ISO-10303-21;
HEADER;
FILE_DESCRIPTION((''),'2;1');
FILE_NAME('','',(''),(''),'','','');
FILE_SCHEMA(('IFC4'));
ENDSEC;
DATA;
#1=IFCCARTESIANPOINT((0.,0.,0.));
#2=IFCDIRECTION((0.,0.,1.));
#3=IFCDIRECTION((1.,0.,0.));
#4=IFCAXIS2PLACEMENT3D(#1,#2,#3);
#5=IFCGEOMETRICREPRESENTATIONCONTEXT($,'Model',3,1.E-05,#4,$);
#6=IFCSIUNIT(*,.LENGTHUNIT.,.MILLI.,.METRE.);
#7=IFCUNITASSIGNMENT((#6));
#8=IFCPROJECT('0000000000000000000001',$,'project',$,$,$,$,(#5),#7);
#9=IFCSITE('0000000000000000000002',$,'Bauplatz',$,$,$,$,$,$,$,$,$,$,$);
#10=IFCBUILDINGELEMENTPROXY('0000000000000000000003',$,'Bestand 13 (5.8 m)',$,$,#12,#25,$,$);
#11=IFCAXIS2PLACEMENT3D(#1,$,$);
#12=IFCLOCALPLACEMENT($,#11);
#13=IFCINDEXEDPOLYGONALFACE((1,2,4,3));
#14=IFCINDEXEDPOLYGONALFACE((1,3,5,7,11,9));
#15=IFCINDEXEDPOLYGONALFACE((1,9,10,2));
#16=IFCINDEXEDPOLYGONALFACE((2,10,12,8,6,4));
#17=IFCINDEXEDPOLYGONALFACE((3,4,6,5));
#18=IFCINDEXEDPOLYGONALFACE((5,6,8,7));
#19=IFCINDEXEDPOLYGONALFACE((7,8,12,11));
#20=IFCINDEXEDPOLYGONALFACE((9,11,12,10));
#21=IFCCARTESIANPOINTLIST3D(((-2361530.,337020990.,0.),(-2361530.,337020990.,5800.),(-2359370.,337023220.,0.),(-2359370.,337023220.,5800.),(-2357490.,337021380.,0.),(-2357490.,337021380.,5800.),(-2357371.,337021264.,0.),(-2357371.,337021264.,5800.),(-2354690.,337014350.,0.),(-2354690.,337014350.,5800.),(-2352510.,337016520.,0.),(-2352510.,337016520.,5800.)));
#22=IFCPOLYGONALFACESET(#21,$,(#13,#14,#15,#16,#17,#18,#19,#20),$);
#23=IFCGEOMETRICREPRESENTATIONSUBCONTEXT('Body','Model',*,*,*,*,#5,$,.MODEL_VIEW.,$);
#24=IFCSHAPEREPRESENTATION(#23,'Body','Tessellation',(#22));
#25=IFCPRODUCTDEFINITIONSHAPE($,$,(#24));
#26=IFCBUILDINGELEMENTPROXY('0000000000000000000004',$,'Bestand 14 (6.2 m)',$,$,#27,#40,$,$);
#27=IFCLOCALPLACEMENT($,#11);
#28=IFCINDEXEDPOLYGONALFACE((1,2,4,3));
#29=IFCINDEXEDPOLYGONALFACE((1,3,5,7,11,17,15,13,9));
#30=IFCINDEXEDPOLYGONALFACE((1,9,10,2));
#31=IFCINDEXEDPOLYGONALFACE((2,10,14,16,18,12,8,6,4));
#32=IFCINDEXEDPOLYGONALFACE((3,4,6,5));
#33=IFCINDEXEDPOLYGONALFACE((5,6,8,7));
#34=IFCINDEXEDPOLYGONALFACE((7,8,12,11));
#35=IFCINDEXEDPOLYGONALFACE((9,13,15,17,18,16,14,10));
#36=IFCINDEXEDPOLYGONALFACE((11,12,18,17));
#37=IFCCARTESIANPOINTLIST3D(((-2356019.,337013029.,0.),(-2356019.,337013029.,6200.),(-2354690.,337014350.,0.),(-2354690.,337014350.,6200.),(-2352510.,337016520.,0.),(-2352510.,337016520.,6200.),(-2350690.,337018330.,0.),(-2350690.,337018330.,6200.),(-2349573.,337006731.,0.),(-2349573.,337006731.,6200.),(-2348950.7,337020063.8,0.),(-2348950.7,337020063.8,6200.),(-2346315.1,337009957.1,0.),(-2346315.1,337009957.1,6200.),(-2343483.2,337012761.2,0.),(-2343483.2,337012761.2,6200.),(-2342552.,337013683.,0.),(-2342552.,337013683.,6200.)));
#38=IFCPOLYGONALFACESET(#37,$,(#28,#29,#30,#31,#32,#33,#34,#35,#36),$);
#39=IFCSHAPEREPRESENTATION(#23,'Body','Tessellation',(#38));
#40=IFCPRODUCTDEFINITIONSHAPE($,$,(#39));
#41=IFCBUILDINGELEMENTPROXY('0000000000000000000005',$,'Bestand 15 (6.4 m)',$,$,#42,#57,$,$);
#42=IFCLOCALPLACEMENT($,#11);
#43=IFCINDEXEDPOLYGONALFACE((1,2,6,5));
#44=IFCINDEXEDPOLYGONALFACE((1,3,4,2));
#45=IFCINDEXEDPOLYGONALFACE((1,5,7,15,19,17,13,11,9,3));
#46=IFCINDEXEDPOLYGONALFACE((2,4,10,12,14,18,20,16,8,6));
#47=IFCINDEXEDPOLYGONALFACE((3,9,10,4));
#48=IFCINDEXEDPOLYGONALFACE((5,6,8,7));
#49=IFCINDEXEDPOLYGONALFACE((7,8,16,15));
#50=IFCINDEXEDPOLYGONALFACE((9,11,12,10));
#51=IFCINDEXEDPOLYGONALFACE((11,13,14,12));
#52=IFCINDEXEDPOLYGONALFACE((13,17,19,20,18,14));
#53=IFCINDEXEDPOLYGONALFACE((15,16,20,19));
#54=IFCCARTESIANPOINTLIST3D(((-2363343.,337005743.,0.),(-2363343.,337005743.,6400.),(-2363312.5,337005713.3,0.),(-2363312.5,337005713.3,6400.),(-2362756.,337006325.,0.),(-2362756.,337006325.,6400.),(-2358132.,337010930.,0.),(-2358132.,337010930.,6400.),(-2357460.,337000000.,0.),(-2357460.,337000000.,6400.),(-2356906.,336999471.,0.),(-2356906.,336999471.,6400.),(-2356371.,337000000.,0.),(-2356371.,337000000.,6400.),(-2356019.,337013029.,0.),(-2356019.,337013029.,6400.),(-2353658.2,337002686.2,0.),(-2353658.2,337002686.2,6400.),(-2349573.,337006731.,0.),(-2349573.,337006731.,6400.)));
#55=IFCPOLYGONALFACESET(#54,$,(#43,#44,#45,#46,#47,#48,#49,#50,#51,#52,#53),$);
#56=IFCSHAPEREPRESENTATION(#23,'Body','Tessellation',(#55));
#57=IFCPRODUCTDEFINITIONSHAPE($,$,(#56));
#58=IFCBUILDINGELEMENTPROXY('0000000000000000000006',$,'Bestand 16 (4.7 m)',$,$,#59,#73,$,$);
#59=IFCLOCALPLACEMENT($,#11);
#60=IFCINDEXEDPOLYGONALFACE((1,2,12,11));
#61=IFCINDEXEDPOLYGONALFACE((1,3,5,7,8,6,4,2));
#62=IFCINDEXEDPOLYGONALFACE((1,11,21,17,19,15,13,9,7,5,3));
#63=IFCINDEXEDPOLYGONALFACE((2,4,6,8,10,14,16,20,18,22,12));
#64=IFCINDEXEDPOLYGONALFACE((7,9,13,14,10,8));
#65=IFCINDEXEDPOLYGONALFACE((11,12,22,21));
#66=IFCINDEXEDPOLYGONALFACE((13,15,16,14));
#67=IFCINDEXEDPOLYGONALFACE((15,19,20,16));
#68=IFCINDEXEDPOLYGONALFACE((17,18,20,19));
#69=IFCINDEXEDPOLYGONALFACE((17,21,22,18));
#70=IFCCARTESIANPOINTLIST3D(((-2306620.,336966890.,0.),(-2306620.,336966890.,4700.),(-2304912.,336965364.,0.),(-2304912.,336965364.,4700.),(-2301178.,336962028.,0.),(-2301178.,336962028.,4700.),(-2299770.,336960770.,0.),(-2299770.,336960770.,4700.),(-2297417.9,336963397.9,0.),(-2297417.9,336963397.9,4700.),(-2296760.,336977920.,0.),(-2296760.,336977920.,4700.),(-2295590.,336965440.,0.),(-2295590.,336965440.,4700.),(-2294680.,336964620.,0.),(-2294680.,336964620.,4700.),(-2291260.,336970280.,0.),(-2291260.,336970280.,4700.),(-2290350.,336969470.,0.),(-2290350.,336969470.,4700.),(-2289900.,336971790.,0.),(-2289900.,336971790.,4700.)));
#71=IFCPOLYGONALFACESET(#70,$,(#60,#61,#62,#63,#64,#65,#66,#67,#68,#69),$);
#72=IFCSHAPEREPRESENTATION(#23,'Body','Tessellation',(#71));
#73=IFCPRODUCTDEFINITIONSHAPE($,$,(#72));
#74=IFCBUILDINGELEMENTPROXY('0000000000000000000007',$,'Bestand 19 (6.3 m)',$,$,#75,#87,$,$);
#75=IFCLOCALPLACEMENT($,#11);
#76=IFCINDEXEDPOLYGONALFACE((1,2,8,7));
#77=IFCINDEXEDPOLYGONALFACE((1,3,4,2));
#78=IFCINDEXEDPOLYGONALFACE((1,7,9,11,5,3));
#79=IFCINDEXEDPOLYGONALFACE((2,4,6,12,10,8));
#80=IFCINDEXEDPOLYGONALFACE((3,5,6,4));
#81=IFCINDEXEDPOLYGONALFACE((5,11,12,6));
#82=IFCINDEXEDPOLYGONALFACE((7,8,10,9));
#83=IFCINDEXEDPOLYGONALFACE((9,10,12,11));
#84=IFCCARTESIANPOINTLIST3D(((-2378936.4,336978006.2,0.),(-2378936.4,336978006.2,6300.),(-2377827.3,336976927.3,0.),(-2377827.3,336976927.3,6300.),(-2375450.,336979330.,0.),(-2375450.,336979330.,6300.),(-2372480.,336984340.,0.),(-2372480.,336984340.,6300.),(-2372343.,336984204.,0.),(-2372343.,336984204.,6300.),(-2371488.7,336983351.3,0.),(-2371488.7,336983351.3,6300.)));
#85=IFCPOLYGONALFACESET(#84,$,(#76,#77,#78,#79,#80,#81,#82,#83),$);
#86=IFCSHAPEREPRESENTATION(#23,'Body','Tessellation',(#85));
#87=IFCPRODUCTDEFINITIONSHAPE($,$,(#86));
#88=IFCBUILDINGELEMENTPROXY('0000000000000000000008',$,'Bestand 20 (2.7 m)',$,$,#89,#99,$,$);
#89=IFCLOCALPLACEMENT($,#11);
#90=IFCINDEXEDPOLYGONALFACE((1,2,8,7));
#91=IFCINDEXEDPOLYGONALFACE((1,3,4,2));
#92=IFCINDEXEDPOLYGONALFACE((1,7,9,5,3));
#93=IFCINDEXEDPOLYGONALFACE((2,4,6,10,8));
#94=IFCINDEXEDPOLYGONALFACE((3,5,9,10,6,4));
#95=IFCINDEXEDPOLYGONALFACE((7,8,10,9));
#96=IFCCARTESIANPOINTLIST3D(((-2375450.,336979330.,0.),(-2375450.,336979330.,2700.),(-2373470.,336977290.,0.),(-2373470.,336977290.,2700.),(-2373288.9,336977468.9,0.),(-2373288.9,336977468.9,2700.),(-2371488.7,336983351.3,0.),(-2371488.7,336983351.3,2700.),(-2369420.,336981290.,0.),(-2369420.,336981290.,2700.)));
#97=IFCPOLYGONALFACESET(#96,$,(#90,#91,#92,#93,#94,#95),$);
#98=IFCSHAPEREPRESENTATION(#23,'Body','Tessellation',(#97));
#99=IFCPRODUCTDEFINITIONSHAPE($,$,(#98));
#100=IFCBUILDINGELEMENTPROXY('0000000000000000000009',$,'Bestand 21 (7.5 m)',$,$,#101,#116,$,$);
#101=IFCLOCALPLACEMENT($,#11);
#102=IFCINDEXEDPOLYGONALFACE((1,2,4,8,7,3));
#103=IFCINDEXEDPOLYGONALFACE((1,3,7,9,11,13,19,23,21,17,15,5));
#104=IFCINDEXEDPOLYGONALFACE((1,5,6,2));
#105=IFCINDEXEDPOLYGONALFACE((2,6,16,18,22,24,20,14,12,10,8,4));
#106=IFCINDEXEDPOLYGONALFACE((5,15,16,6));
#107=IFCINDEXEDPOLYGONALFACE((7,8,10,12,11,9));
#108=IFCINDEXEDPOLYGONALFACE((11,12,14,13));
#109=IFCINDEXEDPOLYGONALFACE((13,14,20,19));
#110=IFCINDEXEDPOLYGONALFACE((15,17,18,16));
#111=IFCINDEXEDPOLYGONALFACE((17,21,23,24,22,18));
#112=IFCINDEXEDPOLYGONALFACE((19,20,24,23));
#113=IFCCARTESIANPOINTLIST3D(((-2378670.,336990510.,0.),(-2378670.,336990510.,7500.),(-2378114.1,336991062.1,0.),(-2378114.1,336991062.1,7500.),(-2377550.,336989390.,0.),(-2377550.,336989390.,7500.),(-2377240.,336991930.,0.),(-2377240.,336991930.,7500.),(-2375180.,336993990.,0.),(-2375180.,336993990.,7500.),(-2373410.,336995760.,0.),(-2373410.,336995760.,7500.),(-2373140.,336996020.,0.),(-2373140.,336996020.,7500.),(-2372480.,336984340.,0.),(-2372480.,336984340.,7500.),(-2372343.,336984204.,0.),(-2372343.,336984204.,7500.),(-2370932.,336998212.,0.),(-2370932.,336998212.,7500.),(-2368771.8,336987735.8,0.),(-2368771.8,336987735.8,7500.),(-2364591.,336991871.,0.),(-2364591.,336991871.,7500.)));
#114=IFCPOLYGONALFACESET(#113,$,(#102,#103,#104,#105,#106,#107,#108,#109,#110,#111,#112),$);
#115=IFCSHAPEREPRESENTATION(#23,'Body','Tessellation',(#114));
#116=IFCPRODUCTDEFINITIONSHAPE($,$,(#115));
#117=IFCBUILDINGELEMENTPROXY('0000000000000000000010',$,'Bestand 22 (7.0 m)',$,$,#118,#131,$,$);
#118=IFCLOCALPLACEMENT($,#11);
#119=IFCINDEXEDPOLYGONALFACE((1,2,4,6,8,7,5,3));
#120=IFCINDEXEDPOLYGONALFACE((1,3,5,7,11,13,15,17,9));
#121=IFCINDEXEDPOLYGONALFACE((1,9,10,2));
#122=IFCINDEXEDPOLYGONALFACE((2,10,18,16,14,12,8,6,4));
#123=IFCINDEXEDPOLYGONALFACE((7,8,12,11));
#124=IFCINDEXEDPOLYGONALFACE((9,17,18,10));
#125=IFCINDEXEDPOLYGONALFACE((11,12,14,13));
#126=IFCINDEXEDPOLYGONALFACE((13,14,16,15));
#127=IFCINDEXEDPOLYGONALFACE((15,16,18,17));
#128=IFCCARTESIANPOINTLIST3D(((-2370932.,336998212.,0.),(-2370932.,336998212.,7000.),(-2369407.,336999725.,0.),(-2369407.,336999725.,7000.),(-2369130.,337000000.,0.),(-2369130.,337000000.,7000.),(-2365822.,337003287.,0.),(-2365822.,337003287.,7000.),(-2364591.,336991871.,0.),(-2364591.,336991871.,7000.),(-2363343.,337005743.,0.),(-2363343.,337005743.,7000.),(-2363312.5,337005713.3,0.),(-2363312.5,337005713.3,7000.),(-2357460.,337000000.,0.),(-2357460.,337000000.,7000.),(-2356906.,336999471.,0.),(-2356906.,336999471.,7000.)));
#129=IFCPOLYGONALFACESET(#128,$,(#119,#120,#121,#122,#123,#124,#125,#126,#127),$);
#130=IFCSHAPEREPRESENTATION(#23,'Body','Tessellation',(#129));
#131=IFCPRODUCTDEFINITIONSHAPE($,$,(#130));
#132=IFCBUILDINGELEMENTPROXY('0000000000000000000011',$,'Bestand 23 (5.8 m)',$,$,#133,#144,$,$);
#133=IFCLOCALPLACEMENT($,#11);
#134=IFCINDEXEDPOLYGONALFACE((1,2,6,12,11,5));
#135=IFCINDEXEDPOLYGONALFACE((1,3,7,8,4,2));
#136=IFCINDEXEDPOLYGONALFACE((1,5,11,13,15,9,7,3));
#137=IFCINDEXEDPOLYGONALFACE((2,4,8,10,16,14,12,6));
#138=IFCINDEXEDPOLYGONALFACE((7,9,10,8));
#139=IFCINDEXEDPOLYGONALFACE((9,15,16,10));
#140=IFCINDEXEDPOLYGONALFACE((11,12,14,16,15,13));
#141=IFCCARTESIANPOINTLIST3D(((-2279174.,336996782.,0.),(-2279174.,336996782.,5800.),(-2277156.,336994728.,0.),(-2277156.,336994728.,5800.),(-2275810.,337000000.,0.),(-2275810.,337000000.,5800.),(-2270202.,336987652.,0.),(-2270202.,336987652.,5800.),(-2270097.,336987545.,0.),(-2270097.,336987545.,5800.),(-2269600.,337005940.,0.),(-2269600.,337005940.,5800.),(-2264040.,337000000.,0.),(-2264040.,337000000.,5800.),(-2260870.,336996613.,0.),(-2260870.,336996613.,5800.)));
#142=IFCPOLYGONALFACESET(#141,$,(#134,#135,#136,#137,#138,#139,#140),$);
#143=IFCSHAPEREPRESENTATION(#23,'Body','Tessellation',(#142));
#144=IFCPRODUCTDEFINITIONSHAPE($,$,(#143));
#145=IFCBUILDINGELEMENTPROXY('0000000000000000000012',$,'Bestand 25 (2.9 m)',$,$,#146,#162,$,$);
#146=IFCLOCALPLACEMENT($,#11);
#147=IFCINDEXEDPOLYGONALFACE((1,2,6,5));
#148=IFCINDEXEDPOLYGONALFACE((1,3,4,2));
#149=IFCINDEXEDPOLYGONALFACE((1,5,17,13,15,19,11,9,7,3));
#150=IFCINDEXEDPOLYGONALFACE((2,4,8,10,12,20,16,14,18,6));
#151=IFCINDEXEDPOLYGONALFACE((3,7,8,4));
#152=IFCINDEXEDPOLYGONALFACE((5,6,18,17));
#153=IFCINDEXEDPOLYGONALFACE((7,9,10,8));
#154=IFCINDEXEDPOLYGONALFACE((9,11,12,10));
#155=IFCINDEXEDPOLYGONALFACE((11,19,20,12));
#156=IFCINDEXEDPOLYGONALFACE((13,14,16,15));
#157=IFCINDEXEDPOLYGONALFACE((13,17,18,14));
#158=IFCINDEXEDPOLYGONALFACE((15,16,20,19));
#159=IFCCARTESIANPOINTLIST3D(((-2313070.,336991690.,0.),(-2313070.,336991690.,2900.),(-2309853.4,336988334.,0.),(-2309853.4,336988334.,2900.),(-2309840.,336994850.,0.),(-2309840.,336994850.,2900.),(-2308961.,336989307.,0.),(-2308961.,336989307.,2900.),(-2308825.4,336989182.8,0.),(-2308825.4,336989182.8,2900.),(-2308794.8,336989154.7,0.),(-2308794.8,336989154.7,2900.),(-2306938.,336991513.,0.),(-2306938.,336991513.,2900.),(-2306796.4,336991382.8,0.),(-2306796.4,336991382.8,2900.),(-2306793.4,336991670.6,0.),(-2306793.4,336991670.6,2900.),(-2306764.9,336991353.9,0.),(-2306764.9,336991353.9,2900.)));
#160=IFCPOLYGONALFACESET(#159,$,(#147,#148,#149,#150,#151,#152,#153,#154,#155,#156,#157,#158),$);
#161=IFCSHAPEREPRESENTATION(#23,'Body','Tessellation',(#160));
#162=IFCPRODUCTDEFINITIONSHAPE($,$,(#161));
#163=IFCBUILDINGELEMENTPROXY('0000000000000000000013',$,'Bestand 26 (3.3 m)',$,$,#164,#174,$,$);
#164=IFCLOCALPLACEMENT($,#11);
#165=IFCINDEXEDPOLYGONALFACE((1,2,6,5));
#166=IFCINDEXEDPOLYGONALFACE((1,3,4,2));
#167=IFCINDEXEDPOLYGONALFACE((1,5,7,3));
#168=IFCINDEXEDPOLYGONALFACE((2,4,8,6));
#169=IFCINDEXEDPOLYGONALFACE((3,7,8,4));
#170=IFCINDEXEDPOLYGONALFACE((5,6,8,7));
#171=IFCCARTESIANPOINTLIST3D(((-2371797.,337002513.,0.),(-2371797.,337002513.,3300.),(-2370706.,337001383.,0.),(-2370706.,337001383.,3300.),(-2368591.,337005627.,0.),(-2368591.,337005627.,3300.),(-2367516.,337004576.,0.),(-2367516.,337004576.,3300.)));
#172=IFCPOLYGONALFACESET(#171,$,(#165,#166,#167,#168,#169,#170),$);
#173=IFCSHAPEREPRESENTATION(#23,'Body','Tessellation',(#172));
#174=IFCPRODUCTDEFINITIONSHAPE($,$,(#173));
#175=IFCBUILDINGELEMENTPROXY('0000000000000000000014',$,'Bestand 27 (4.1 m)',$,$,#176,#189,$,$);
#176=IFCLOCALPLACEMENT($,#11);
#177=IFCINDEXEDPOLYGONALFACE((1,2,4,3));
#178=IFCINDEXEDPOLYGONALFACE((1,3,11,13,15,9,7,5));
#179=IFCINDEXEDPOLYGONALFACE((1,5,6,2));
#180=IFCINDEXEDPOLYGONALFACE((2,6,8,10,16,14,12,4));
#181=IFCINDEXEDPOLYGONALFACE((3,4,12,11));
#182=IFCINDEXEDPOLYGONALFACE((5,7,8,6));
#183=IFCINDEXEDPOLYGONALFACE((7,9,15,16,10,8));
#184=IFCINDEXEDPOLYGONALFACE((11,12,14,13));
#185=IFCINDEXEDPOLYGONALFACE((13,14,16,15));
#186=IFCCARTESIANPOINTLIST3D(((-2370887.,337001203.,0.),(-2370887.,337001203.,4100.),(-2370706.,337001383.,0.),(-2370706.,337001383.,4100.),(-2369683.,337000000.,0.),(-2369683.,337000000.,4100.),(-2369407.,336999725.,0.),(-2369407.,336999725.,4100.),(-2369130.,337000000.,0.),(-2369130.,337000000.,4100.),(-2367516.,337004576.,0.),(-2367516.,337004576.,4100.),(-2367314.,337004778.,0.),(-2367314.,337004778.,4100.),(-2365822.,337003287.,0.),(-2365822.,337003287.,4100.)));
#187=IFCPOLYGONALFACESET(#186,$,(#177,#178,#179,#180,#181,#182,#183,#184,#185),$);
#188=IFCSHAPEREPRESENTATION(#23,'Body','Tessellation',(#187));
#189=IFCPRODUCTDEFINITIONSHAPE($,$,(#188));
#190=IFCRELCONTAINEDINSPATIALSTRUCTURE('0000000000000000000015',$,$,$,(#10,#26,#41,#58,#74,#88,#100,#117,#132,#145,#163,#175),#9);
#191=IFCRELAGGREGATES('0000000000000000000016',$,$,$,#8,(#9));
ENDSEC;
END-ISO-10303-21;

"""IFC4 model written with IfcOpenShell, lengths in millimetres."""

from ifc_helpers import new_model, si_unit, origin_with_axes, place, context, subcontext, project, spatial, indexed_curve, outline, extrude, element, save


model = new_model("IFC4")

# Units and contexts
model_context = context("Model", 3, precision=1e-05, world=origin_with_axes())
body_context = subcontext(model_context, "Body", "Model", "MODEL_VIEW")
ifc_project = project(units=[si_unit("LENGTHUNIT", "METRE", prefix="MILLI")], contexts=[model_context])

# Site
site = spatial("IfcSite", under=ifc_project, Name="Bauplatz")

# Building element proxies
proxy_1_placement = place(None, origin_with_axes())
element("IfcBuildingElementProxy", 1, at=proxy_1_placement, inside=site, Name="Bestand 13 (5.8 m)", context=body_context, shape_type="SweptSolid", body=[
    extrude(outline(indexed_curve([(-2357490.0, 337021380.0), (-2359370.0, 337023220.0), (-2361530.0, 337020990.0), (-2354690.0, 337014350.0), (-2352510.0, 337016520.0), (-2357371.0, 337021264.0)])), None, (0.0, 0.0, 1.0), 5800.0),
])
proxy_2_placement = place(None, origin_with_axes())
element("IfcBuildingElementProxy", 2, at=proxy_2_placement, inside=site, Name="Bestand 14 (6.2 m)", context=body_context, shape_type="SweptSolid", body=[
    extrude(outline(indexed_curve([(-2342552.0, 337013683.0), (-2348950.7, 337020063.8), (-2350690.0, 337018330.0), (-2352510.0, 337016520.0), (-2354690.0, 337014350.0), (-2356019.0, 337013029.0), (-2349573.0, 337006731.0), (-2346315.1, 337009957.1), (-2343483.2, 337012761.2)])), None, (0.0, 0.0, 1.0), 6200.0),
])
proxy_3_placement = place(None, origin_with_axes())
element("IfcBuildingElementProxy", 3, at=proxy_3_placement, inside=site, Name="Bestand 15 (6.4 m)", context=body_context, shape_type="SweptSolid", body=[
    extrude(outline(indexed_curve([(-2349573.0, 337006731.0), (-2356019.0, 337013029.0), (-2358132.0, 337010930.0), (-2362756.0, 337006325.0), (-2363343.0, 337005743.0), (-2363312.5, 337005713.3), (-2357460.0, 337000000.0), (-2356906.0, 336999471.0), (-2356371.0, 337000000.0), (-2353658.2, 337002686.2)])), None, (0.0, 0.0, 1.0), 6400.0),
])
proxy_4_placement = place(None, origin_with_axes())
element("IfcBuildingElementProxy", 4, at=proxy_4_placement, inside=site, Name="Bestand 16 (4.7 m)", context=body_context, shape_type="SweptSolid", body=[
    extrude(outline(indexed_curve([(-2289900.0, 336971790.0), (-2296760.0, 336977920.0), (-2306620.0, 336966890.0), (-2304912.0, 336965364.0), (-2301178.0, 336962028.0), (-2299770.0, 336960770.0), (-2297417.9, 336963397.9), (-2295590.0, 336965440.0), (-2294680.0, 336964620.0), (-2290350.0, 336969470.0), (-2291260.0, 336970280.0)])), None, (0.0, 0.0, 1.0), 4700.0),
])
proxy_5_placement = place(None, origin_with_axes())
element("IfcBuildingElementProxy", 5, at=proxy_5_placement, inside=site, Name="Bestand 19 (6.3 m)", context=body_context, shape_type="SweptSolid", body=[
    extrude(outline(indexed_curve([(-2372343.0, 336984204.0), (-2372480.0, 336984340.0), (-2378936.4, 336978006.2), (-2377827.3, 336976927.3), (-2375450.0, 336979330.0), (-2371488.7, 336983351.3)])), None, (0.0, 0.0, 1.0), 6300.0),
])
proxy_6_placement = place(None, origin_with_axes())
element("IfcBuildingElementProxy", 6, at=proxy_6_placement, inside=site, Name="Bestand 20 (2.7 m)", context=body_context, shape_type="SweptSolid", body=[
    extrude(outline(indexed_curve([(-2369420.0, 336981290.0), (-2371488.7, 336983351.3), (-2375450.0, 336979330.0), (-2373470.0, 336977290.0), (-2373288.9, 336977468.9)])), None, (0.0, 0.0, 1.0), 2700.0),
])
proxy_7_placement = place(None, origin_with_axes())
element("IfcBuildingElementProxy", 7, at=proxy_7_placement, inside=site, Name="Bestand 21 (7.5 m)", context=body_context, shape_type="SweptSolid", body=[
    extrude(outline(indexed_curve([(-2364591.0, 336991871.0), (-2370932.0, 336998212.0), (-2373140.0, 336996020.0), (-2373410.0, 336995760.0), (-2375180.0, 336993990.0), (-2377240.0, 336991930.0), (-2378114.1, 336991062.1), (-2378670.0, 336990510.0), (-2377550.0, 336989390.0), (-2372480.0, 336984340.0), (-2372343.0, 336984204.0), (-2368771.8, 336987735.8)])), None, (0.0, 0.0, 1.0), 7500.0),
])
proxy_8_placement = place(None, origin_with_axes())
element("IfcBuildingElementProxy", 8, at=proxy_8_placement, inside=site, Name="Bestand 22 (7.0 m)", context=body_context, shape_type="SweptSolid", body=[
    extrude(outline(indexed_curve([(-2363312.5, 337005713.3), (-2363343.0, 337005743.0), (-2365822.0, 337003287.0), (-2369130.0, 337000000.0), (-2369407.0, 336999725.0), (-2370932.0, 336998212.0), (-2364591.0, 336991871.0), (-2356906.0, 336999471.0), (-2357460.0, 337000000.0)])), None, (0.0, 0.0, 1.0), 7000.0),
])
proxy_9_placement = place(None, origin_with_axes())
element("IfcBuildingElementProxy", 9, at=proxy_9_placement, inside=site, Name="Bestand 23 (5.8 m)", context=body_context, shape_type="SweptSolid", body=[
    extrude(outline(indexed_curve([(-2264040.0, 337000000.0), (-2269600.0, 337005940.0), (-2275810.0, 337000000.0), (-2279174.0, 336996782.0), (-2277156.0, 336994728.0), (-2270202.0, 336987652.0), (-2270097.0, 336987545.0), (-2260870.0, 336996613.0)])), None, (0.0, 0.0, 1.0), 5800.0),
])
proxy_10_placement = place(None, origin_with_axes())
element("IfcBuildingElementProxy", 10, at=proxy_10_placement, inside=site, Name="Bestand 25 (2.9 m)", context=body_context, shape_type="SweptSolid", body=[
    extrude(outline(indexed_curve([(-2306793.4, 336991670.6), (-2309840.0, 336994850.0), (-2313070.0, 336991690.0), (-2309853.4, 336988334.0), (-2308961.0, 336989307.0), (-2308825.4, 336989182.8), (-2308794.8, 336989154.7), (-2306764.9, 336991353.9), (-2306796.4, 336991382.8), (-2306938.0, 336991513.0)])), None, (0.0, 0.0, 1.0), 2900.0),
])
proxy_11_placement = place(None, origin_with_axes())
element("IfcBuildingElementProxy", 11, at=proxy_11_placement, inside=site, Name="Bestand 26 (3.3 m)", context=body_context, shape_type="SweptSolid", body=[
    extrude(outline(indexed_curve([(-2367516.0, 337004576.0), (-2368591.0, 337005627.0), (-2371797.0, 337002513.0), (-2370706.0, 337001383.0)])), None, (0.0, 0.0, 1.0), 3300.0),
])
proxy_12_placement = place(None, origin_with_axes())
element("IfcBuildingElementProxy", 12, at=proxy_12_placement, inside=site, Name="Bestand 27 (4.1 m)", context=body_context, shape_type="SweptSolid", body=[
    extrude(outline(indexed_curve([(-2365822.0, 337003287.0), (-2367314.0, 337004778.0), (-2367516.0, 337004576.0), (-2370706.0, 337001383.0), (-2370887.0, 337001203.0), (-2369683.0, 337000000.0), (-2369407.0, 336999725.0), (-2369130.0, 337000000.0)])), None, (0.0, 0.0, 1.0), 4100.0),
])

save(model, "model.ifc")
